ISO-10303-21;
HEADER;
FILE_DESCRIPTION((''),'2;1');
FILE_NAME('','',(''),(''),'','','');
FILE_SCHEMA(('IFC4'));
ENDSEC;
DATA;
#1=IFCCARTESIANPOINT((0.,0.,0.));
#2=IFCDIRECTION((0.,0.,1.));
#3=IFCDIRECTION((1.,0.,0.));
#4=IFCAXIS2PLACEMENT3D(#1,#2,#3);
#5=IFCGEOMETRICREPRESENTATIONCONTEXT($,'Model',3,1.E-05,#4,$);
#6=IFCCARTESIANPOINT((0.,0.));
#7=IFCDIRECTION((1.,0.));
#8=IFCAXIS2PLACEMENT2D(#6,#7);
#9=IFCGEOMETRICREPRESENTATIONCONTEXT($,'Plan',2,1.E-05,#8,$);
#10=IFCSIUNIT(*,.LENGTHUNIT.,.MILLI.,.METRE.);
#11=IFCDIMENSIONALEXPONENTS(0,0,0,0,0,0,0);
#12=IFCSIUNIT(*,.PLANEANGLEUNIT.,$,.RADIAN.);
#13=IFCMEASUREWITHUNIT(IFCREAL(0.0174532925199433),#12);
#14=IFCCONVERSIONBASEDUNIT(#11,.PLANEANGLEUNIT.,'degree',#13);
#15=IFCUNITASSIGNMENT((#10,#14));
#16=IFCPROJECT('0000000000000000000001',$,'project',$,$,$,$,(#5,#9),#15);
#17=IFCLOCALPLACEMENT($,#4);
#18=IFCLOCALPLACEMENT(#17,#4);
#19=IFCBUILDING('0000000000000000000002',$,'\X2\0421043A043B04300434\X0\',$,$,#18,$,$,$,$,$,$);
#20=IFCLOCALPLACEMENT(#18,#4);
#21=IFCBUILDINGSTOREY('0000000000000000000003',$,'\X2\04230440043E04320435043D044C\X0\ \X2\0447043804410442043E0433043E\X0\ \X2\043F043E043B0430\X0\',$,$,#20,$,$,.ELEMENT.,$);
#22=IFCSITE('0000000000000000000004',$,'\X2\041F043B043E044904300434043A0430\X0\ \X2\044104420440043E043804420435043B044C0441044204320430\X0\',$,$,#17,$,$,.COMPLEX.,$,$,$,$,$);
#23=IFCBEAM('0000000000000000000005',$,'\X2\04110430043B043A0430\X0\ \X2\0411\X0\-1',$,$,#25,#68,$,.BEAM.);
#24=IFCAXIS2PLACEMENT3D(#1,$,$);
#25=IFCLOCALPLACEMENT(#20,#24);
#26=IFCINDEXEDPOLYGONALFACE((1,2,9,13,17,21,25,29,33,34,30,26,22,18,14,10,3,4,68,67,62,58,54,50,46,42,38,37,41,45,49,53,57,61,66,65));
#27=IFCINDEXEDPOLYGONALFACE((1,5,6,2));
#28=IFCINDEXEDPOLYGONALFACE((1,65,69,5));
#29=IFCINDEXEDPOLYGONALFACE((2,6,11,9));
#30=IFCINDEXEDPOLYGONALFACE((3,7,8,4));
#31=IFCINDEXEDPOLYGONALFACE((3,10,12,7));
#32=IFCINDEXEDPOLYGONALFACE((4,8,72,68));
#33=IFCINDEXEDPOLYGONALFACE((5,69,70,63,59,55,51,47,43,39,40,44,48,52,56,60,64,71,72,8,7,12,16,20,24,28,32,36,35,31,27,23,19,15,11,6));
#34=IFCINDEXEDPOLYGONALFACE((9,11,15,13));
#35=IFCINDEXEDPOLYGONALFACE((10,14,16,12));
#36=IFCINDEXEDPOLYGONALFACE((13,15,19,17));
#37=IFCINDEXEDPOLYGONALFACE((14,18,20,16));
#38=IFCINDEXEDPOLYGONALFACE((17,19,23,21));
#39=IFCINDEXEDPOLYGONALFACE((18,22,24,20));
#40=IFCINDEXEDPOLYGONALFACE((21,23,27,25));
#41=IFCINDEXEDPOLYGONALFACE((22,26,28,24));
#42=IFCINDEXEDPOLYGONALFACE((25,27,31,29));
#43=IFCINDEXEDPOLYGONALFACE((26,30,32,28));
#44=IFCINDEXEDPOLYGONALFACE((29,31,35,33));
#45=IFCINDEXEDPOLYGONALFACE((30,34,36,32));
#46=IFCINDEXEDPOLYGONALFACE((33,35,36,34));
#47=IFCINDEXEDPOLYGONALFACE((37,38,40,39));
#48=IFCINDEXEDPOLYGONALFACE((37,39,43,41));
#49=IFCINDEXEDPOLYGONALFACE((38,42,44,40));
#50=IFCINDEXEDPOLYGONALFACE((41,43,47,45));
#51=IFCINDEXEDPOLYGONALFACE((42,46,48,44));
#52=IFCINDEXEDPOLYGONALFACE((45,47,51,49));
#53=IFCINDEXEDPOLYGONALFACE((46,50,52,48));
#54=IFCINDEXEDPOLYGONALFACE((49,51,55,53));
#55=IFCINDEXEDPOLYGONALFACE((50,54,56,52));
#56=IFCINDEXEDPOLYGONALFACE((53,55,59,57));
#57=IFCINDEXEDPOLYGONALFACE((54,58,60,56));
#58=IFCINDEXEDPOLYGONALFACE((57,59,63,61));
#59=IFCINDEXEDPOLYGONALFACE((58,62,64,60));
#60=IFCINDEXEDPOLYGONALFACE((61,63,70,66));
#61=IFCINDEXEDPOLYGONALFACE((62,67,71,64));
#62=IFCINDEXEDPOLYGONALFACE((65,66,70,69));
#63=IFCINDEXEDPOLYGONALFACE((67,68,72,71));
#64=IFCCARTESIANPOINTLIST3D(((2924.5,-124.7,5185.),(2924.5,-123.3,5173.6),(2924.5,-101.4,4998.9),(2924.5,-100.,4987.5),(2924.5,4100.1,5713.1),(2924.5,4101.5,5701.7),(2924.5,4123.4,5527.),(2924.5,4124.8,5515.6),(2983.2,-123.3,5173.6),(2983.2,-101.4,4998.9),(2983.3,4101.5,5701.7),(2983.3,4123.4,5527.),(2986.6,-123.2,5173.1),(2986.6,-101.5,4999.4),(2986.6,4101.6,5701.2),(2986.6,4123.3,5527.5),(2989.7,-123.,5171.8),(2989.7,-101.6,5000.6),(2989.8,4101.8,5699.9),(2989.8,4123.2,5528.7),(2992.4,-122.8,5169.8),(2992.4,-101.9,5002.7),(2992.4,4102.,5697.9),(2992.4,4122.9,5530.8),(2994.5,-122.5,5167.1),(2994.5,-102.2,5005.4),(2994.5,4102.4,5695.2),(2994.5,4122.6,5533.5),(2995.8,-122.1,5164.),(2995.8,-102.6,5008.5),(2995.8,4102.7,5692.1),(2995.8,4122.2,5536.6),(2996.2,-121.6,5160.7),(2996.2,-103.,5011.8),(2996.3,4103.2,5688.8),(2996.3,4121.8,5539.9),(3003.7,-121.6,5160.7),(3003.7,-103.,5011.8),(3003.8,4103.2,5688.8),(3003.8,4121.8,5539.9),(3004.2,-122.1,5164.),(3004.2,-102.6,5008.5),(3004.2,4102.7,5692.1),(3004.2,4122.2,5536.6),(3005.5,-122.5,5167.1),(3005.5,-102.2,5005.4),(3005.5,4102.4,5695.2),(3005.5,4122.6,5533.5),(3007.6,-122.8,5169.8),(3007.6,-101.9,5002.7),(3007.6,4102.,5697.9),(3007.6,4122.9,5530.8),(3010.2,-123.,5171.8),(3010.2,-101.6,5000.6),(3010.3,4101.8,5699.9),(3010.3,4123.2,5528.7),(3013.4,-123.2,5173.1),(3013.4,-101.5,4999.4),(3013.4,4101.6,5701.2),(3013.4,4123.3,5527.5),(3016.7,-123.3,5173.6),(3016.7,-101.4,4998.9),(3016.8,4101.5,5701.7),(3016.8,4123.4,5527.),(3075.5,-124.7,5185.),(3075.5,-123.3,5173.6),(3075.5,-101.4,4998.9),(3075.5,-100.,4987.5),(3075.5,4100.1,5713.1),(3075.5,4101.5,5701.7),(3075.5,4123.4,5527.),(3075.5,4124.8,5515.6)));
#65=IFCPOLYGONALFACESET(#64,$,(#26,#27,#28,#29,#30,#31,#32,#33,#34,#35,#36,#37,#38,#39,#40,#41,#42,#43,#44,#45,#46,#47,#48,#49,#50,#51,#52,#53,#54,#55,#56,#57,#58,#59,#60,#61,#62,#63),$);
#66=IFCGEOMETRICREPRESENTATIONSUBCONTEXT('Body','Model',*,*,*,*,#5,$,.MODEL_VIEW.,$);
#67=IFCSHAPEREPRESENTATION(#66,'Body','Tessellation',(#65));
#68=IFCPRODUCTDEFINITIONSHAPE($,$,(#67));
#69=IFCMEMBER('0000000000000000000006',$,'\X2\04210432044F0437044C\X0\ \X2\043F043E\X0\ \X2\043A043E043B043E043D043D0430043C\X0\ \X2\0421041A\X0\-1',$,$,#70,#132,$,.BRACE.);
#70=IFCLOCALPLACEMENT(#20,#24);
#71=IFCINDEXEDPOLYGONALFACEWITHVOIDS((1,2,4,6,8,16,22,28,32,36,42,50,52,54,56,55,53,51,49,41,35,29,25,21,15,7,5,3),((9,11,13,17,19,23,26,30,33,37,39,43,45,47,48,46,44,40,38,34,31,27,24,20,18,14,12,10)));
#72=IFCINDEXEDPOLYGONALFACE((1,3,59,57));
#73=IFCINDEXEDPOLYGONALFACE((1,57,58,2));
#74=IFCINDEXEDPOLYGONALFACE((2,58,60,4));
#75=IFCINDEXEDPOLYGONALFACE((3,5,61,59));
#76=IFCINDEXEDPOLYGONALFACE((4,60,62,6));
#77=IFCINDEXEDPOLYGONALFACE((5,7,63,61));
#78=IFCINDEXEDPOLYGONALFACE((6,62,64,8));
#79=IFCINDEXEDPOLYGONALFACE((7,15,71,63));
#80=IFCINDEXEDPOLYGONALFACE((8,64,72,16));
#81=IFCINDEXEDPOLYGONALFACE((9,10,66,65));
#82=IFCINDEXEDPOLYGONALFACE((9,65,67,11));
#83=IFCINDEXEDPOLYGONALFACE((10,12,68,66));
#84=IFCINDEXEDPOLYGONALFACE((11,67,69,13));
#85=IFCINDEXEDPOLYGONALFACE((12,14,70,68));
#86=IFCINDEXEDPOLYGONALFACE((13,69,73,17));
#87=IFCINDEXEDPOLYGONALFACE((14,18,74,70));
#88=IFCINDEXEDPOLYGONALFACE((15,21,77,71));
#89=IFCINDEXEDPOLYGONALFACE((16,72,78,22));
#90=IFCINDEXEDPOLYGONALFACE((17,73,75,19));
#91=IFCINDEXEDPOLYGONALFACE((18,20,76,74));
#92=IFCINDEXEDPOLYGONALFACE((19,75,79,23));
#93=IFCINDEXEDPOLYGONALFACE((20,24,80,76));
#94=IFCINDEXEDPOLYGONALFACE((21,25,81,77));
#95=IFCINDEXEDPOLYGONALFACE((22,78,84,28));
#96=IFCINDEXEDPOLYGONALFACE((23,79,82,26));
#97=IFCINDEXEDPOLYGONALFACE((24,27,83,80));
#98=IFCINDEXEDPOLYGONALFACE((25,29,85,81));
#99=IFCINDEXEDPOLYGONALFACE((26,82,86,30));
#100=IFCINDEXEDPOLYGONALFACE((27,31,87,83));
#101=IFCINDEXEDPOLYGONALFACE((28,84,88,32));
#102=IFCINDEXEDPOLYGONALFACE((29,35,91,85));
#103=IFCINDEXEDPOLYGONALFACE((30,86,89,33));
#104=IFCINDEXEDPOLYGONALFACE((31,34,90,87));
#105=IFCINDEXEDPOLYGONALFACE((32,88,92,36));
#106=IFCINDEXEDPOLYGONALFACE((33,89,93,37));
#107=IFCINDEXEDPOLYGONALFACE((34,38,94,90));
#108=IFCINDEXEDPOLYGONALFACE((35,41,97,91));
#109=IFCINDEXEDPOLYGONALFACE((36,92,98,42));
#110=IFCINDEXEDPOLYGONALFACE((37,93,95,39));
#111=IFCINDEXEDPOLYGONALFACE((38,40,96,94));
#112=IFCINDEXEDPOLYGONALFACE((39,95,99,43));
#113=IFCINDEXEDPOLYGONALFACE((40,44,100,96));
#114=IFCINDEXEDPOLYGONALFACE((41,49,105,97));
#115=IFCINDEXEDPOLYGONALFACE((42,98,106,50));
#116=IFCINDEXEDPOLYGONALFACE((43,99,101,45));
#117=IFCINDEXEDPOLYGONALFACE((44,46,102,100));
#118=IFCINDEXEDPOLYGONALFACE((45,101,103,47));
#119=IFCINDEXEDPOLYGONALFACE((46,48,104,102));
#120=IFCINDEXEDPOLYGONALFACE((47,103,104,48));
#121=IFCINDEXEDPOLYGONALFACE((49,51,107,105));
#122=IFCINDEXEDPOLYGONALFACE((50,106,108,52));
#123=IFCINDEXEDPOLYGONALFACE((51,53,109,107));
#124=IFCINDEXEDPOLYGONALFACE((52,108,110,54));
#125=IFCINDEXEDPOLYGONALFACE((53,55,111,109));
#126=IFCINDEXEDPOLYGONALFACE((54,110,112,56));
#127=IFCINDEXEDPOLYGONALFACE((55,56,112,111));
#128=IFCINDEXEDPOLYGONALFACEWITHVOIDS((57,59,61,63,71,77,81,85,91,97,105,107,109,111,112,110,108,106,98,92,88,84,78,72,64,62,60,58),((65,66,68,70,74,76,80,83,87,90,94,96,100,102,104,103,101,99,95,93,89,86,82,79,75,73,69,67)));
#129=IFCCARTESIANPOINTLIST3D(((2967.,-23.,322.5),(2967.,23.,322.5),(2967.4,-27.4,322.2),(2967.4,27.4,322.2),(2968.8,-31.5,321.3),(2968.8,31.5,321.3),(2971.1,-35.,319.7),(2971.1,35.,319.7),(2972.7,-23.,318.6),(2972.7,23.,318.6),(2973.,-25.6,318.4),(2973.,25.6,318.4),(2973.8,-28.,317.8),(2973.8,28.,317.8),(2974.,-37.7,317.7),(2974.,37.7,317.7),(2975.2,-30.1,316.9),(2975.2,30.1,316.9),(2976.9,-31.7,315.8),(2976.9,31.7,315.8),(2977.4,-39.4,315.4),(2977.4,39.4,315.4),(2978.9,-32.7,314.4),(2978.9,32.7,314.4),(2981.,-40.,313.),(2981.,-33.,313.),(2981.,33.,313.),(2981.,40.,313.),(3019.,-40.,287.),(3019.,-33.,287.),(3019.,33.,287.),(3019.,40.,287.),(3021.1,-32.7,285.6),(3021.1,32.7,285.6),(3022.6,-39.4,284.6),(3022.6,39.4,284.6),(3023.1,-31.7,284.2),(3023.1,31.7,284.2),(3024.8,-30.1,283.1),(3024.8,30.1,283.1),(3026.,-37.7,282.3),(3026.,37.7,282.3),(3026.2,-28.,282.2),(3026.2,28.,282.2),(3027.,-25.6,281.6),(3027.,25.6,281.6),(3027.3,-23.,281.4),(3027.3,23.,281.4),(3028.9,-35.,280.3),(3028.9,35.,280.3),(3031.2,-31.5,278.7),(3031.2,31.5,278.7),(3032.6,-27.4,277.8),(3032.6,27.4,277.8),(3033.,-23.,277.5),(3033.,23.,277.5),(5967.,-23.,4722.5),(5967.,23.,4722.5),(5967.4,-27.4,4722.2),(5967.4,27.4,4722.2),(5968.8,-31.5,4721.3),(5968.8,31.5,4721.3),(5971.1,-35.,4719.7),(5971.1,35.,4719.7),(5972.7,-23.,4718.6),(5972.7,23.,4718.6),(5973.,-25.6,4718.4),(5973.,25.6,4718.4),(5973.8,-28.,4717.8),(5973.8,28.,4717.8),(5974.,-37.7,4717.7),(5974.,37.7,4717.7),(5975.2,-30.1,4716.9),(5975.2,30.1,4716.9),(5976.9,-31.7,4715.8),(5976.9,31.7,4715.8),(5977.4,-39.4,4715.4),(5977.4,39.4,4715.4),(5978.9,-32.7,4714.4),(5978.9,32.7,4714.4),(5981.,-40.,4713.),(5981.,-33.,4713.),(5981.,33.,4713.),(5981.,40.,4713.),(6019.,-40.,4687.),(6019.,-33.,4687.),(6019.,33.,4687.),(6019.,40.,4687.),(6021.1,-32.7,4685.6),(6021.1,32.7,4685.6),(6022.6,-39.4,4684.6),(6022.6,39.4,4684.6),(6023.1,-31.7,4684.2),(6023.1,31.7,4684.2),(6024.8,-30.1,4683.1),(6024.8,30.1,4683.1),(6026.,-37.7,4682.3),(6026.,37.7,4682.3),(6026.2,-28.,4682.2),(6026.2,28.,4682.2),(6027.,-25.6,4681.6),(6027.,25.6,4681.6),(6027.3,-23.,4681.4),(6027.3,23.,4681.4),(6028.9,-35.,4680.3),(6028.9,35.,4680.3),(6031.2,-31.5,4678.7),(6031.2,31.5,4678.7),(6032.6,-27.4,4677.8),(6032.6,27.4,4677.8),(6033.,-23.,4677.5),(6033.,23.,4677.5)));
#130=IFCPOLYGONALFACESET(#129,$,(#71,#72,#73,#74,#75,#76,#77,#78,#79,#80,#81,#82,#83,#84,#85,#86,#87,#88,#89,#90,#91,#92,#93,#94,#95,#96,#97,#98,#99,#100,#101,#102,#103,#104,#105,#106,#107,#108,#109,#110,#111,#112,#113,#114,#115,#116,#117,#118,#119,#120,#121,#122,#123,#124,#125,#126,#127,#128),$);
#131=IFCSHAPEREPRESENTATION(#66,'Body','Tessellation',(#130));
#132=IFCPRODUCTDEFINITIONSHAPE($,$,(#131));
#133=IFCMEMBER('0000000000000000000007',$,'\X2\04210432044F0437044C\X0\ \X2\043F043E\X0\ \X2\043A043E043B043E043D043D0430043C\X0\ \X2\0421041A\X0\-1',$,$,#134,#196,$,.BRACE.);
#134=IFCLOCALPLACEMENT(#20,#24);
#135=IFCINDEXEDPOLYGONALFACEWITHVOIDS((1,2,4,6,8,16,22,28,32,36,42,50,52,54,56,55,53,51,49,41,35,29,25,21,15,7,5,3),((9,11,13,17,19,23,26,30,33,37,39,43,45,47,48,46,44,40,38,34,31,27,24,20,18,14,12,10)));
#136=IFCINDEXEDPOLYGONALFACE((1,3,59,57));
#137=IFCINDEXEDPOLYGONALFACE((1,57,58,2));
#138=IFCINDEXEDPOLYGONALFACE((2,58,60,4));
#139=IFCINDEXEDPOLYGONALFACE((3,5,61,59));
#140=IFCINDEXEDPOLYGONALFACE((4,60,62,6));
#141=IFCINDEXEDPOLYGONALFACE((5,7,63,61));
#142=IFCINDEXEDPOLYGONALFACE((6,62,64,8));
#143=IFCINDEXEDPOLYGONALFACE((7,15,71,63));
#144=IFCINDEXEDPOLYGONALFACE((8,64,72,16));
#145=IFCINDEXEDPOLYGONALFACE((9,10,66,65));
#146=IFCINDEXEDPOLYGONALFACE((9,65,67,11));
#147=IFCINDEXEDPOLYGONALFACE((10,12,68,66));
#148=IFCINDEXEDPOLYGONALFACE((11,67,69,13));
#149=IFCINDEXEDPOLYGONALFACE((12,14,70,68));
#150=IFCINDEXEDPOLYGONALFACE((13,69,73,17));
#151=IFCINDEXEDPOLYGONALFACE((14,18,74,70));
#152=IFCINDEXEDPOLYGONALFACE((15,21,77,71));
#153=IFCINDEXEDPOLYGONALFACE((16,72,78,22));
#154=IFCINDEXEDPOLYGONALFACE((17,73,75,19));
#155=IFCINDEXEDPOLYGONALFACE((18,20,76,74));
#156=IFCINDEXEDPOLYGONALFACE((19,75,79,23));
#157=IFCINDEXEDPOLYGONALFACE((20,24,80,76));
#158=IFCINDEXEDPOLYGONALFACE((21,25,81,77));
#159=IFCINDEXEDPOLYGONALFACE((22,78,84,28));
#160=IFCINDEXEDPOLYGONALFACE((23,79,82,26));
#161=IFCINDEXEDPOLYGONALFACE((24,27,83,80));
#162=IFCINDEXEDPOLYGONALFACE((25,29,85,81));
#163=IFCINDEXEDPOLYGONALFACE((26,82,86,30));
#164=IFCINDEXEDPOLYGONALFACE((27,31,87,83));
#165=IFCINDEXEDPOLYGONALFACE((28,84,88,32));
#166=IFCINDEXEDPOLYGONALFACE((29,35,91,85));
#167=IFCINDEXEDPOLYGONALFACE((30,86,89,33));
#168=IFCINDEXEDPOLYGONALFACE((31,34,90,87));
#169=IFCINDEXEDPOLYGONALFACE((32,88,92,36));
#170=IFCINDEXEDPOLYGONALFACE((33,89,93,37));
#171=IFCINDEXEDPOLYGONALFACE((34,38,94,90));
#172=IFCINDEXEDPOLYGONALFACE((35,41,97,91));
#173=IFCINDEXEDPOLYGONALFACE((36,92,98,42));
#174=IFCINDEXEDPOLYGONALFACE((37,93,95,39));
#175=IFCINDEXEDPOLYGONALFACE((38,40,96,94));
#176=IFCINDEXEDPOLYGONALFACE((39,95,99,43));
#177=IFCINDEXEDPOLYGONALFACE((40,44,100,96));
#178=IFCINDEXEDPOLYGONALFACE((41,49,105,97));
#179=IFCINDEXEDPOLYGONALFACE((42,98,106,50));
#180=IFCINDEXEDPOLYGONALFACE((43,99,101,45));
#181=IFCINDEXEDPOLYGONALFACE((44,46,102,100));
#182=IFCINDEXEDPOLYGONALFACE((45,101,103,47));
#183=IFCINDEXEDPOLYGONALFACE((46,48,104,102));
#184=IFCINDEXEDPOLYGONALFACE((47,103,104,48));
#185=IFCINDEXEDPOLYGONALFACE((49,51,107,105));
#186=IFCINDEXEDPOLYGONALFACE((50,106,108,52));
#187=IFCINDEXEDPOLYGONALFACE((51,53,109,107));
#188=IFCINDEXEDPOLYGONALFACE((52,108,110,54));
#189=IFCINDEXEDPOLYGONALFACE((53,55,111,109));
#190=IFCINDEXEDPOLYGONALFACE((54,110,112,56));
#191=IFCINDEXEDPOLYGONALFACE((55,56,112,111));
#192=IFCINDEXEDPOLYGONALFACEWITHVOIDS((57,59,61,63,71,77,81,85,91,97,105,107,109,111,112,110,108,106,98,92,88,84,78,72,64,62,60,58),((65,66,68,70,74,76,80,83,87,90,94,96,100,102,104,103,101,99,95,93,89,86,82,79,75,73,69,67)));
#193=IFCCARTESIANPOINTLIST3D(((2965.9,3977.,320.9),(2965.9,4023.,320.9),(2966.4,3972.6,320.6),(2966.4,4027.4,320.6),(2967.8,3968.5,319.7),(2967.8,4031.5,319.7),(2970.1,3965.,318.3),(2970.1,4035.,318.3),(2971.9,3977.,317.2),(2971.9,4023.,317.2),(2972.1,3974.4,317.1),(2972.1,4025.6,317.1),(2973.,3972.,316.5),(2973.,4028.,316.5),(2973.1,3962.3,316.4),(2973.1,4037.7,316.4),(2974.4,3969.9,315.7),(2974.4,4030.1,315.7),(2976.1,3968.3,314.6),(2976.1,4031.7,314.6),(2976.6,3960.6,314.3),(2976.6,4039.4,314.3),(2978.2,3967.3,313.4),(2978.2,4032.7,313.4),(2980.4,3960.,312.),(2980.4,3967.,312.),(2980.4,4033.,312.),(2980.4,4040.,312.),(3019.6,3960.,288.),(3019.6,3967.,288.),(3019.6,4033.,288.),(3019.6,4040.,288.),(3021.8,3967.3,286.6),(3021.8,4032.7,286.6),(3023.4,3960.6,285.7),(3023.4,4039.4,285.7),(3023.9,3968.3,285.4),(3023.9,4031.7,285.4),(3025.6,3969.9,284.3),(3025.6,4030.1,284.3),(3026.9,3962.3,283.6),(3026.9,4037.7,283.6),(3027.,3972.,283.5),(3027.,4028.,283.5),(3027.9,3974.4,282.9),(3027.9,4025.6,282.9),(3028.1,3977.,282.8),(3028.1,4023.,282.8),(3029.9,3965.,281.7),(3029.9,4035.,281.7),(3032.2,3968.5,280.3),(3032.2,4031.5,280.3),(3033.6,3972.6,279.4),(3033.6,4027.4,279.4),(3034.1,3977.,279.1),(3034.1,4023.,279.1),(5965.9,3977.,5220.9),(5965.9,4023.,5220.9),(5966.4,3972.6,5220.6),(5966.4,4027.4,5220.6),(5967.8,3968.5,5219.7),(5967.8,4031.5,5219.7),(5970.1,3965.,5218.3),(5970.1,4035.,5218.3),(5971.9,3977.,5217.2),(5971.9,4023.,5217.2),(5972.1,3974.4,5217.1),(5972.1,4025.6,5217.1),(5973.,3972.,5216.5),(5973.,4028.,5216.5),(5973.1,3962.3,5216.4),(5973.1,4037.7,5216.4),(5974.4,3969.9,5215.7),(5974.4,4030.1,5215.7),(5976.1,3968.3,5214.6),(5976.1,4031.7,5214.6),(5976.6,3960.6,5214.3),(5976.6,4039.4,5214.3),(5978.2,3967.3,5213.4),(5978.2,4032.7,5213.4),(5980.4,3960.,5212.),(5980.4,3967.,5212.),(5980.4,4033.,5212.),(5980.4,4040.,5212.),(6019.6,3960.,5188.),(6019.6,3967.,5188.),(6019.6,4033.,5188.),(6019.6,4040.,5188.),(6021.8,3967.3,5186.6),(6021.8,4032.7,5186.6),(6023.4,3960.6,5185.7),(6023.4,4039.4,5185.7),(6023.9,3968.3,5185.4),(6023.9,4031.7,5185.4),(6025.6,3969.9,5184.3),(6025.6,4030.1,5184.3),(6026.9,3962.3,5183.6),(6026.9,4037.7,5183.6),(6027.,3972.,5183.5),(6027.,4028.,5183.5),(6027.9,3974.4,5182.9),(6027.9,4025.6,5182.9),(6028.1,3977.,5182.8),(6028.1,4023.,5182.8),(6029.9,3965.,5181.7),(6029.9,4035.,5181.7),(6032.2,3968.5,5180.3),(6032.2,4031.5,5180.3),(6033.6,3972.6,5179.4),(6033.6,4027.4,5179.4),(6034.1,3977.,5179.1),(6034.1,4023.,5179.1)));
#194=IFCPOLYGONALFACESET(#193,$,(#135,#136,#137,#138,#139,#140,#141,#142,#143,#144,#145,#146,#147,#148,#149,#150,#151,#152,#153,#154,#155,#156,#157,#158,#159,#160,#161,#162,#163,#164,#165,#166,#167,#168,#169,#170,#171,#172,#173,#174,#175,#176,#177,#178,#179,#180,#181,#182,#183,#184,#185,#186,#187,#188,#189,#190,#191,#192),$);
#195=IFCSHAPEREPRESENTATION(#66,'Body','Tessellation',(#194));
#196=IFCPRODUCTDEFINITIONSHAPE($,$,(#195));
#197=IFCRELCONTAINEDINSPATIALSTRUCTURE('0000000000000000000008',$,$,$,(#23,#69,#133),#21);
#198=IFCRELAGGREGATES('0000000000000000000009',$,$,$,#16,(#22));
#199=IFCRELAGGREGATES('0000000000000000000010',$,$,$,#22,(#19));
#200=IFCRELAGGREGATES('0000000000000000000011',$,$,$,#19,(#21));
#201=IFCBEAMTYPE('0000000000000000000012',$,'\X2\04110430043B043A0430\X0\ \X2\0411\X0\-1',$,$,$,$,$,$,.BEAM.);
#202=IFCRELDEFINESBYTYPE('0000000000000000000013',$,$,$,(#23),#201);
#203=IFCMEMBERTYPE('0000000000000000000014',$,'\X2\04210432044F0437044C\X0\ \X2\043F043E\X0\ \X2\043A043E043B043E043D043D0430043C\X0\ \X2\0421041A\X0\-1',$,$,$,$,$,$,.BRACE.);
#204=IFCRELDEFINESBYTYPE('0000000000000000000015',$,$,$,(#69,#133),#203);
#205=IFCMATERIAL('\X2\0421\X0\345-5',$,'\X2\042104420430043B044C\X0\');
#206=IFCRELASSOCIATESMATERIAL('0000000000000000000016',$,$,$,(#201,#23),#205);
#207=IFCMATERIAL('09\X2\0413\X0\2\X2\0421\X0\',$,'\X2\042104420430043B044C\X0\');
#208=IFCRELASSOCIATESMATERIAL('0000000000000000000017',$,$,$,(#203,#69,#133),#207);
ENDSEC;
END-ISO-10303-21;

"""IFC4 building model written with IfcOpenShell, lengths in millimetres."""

from ifc_helpers import new_model, entity, si_unit, converted_unit, frame, origin_with_axes, origin_2d_with_axis, place, context, subcontext, project, spatial, hollow_rectangle, i_section, extrude, material, material_profile, profile_set, profile_usage, type_object, element, save


model = new_model("IFC4")

# Units and contexts
model_context = context("Model", 3, precision=1e-05, world=origin_with_axes())
plan_context = context("Plan", 2, precision=1e-05, world=origin_2d_with_axis())
body_context = subcontext(model_context, "Body", "Model", "MODEL_VIEW")
ifc_project = project(units=[si_unit("LENGTHUNIT", "METRE", prefix="MILLI"), converted_unit("PLANEANGLEUNIT", "degree", entity("IfcReal", 0.0174532925199433), si_unit("PLANEANGLEUNIT", "RADIAN"), dimensions=[0, 0, 0, 0, 0, 0, 0])], contexts=[model_context, plan_context])

# Site, building, storey
site_placement = place(None, origin_with_axes())
site = spatial("IfcSite", under=ifc_project, at=site_placement, Name="Площадка строительства", CompositionType="COMPLEX")
building_placement = place(site_placement, origin_with_axes())
building = spatial("IfcBuilding", under=site, at=building_placement, Name="Склад")
storey_placement = place(building_placement, origin_with_axes())
storey = spatial("IfcBuildingStorey", under=building, at=storey_placement, Name="Уровень чистого пола", CompositionType="ELEMENT")

# Shared definitions
ifc_material_1 = material(Name="С345-5", Category="Сталь")

# Beam
ifc_material_profile_1 = material_profile(ifc_material_1, i_section(OverallWidth=151.0, OverallDepth=199.0, WebThickness=7.5, FlangeThickness=11.5, FilletRadius=13.0, FlangeEdgeRadius=0.0, FlangeSlope=0.0))
ifc_profile_set_1 = profile_set([ifc_material_profile_1], Name="I20H2_S345-5")
beam_type_1 = type_object("IfcBeamType", Name="Балка Б-1", PredefinedType="BEAM", material=ifc_profile_set_1)
ifc_profile_usage_1 = profile_usage(ifc_profile_set_1, cardinal=2)
beam_1_placement = place(storey_placement, frame((3000.0, -100.0, 4987.5), z_axis=(0.0, 0.992278, 0.124035), x_axis=(-1.0, 0.0, 0.0)))
element("IfcBeam", 1, at=beam_1_placement, inside=storey, type_object=beam_type_1, material=ifc_profile_usage_1, Name="Балка Б-1", PredefinedType="BEAM", context=body_context, shape_type="SweptSolid", body=[
    extrude(i_section(OverallWidth=151.0, OverallDepth=199.0, WebThickness=7.5, FlangeThickness=11.5, FilletRadius=13.0, FlangeEdgeRadius=0.0, FlangeSlope=0.0), frame((0.0, 99.5, 0.0), z_axis=(0.0, 0.0, 1.0), x_axis=(1.0, 0.0, 0.0)), (0.0, 0.0, 1.0), 4257.7),
])

# Members
ifc_material_2 = material(Name="09Г2С", Category="Сталь")
ifc_material_profile_2 = material_profile(ifc_material_2, hollow_rectangle(XDim=80.0, YDim=80.0, WallThickness=7.0, InnerFilletRadius=10.0, OuterFilletRadius=17.0))
ifc_profile_set_2 = profile_set([ifc_material_profile_2], Name="PK80x7_09G2S")
ifc_profile_usage_2 = profile_usage(ifc_profile_set_2, cardinal=5)
member_type_1 = type_object("IfcMemberType", Name="Связь по колоннам СК-1", PredefinedType="BRACE", material=ifc_profile_set_2)
member_1_placement = place(storey_placement, frame((3000.0, 0.0, 300.0), z_axis=(0.563337, 0.0, 0.826227), x_axis=(0.0, 1.0, 0.0)))
element("IfcMember", 2, at=member_1_placement, inside=storey, type_object=member_type_1, material=ifc_profile_usage_2, Name="Связь по колоннам СК-1", PredefinedType="BRACE", context=body_context, shape_type="SweptSolid", body=[
    extrude(hollow_rectangle(XDim=80.0, YDim=80.0, WallThickness=7.0, InnerFilletRadius=10.0, OuterFilletRadius=17.0), origin_with_axes(), (0.0, 0.0, 1.0), 5325.4),
])
ifc_profile_usage_3 = profile_usage(ifc_profile_set_2, cardinal=5)
member_2_placement = place(storey_placement, frame((3000.0, 4000.0, 300.0), z_axis=(0.522154, 0.0, 0.852851), x_axis=(0.0, 1.0, 0.0)))
element("IfcMember", 3, at=member_2_placement, inside=storey, type_object=member_type_1, material=ifc_profile_usage_3, Name="Связь по колоннам СК-1", PredefinedType="BRACE", context=body_context, shape_type="SweptSolid", body=[
    extrude(hollow_rectangle(XDim=80.0, YDim=80.0, WallThickness=7.0, InnerFilletRadius=10.0, OuterFilletRadius=17.0), origin_with_axes(), (0.0, 0.0, 1.0), 5745.4),
])

save(model, "model.ifc")
